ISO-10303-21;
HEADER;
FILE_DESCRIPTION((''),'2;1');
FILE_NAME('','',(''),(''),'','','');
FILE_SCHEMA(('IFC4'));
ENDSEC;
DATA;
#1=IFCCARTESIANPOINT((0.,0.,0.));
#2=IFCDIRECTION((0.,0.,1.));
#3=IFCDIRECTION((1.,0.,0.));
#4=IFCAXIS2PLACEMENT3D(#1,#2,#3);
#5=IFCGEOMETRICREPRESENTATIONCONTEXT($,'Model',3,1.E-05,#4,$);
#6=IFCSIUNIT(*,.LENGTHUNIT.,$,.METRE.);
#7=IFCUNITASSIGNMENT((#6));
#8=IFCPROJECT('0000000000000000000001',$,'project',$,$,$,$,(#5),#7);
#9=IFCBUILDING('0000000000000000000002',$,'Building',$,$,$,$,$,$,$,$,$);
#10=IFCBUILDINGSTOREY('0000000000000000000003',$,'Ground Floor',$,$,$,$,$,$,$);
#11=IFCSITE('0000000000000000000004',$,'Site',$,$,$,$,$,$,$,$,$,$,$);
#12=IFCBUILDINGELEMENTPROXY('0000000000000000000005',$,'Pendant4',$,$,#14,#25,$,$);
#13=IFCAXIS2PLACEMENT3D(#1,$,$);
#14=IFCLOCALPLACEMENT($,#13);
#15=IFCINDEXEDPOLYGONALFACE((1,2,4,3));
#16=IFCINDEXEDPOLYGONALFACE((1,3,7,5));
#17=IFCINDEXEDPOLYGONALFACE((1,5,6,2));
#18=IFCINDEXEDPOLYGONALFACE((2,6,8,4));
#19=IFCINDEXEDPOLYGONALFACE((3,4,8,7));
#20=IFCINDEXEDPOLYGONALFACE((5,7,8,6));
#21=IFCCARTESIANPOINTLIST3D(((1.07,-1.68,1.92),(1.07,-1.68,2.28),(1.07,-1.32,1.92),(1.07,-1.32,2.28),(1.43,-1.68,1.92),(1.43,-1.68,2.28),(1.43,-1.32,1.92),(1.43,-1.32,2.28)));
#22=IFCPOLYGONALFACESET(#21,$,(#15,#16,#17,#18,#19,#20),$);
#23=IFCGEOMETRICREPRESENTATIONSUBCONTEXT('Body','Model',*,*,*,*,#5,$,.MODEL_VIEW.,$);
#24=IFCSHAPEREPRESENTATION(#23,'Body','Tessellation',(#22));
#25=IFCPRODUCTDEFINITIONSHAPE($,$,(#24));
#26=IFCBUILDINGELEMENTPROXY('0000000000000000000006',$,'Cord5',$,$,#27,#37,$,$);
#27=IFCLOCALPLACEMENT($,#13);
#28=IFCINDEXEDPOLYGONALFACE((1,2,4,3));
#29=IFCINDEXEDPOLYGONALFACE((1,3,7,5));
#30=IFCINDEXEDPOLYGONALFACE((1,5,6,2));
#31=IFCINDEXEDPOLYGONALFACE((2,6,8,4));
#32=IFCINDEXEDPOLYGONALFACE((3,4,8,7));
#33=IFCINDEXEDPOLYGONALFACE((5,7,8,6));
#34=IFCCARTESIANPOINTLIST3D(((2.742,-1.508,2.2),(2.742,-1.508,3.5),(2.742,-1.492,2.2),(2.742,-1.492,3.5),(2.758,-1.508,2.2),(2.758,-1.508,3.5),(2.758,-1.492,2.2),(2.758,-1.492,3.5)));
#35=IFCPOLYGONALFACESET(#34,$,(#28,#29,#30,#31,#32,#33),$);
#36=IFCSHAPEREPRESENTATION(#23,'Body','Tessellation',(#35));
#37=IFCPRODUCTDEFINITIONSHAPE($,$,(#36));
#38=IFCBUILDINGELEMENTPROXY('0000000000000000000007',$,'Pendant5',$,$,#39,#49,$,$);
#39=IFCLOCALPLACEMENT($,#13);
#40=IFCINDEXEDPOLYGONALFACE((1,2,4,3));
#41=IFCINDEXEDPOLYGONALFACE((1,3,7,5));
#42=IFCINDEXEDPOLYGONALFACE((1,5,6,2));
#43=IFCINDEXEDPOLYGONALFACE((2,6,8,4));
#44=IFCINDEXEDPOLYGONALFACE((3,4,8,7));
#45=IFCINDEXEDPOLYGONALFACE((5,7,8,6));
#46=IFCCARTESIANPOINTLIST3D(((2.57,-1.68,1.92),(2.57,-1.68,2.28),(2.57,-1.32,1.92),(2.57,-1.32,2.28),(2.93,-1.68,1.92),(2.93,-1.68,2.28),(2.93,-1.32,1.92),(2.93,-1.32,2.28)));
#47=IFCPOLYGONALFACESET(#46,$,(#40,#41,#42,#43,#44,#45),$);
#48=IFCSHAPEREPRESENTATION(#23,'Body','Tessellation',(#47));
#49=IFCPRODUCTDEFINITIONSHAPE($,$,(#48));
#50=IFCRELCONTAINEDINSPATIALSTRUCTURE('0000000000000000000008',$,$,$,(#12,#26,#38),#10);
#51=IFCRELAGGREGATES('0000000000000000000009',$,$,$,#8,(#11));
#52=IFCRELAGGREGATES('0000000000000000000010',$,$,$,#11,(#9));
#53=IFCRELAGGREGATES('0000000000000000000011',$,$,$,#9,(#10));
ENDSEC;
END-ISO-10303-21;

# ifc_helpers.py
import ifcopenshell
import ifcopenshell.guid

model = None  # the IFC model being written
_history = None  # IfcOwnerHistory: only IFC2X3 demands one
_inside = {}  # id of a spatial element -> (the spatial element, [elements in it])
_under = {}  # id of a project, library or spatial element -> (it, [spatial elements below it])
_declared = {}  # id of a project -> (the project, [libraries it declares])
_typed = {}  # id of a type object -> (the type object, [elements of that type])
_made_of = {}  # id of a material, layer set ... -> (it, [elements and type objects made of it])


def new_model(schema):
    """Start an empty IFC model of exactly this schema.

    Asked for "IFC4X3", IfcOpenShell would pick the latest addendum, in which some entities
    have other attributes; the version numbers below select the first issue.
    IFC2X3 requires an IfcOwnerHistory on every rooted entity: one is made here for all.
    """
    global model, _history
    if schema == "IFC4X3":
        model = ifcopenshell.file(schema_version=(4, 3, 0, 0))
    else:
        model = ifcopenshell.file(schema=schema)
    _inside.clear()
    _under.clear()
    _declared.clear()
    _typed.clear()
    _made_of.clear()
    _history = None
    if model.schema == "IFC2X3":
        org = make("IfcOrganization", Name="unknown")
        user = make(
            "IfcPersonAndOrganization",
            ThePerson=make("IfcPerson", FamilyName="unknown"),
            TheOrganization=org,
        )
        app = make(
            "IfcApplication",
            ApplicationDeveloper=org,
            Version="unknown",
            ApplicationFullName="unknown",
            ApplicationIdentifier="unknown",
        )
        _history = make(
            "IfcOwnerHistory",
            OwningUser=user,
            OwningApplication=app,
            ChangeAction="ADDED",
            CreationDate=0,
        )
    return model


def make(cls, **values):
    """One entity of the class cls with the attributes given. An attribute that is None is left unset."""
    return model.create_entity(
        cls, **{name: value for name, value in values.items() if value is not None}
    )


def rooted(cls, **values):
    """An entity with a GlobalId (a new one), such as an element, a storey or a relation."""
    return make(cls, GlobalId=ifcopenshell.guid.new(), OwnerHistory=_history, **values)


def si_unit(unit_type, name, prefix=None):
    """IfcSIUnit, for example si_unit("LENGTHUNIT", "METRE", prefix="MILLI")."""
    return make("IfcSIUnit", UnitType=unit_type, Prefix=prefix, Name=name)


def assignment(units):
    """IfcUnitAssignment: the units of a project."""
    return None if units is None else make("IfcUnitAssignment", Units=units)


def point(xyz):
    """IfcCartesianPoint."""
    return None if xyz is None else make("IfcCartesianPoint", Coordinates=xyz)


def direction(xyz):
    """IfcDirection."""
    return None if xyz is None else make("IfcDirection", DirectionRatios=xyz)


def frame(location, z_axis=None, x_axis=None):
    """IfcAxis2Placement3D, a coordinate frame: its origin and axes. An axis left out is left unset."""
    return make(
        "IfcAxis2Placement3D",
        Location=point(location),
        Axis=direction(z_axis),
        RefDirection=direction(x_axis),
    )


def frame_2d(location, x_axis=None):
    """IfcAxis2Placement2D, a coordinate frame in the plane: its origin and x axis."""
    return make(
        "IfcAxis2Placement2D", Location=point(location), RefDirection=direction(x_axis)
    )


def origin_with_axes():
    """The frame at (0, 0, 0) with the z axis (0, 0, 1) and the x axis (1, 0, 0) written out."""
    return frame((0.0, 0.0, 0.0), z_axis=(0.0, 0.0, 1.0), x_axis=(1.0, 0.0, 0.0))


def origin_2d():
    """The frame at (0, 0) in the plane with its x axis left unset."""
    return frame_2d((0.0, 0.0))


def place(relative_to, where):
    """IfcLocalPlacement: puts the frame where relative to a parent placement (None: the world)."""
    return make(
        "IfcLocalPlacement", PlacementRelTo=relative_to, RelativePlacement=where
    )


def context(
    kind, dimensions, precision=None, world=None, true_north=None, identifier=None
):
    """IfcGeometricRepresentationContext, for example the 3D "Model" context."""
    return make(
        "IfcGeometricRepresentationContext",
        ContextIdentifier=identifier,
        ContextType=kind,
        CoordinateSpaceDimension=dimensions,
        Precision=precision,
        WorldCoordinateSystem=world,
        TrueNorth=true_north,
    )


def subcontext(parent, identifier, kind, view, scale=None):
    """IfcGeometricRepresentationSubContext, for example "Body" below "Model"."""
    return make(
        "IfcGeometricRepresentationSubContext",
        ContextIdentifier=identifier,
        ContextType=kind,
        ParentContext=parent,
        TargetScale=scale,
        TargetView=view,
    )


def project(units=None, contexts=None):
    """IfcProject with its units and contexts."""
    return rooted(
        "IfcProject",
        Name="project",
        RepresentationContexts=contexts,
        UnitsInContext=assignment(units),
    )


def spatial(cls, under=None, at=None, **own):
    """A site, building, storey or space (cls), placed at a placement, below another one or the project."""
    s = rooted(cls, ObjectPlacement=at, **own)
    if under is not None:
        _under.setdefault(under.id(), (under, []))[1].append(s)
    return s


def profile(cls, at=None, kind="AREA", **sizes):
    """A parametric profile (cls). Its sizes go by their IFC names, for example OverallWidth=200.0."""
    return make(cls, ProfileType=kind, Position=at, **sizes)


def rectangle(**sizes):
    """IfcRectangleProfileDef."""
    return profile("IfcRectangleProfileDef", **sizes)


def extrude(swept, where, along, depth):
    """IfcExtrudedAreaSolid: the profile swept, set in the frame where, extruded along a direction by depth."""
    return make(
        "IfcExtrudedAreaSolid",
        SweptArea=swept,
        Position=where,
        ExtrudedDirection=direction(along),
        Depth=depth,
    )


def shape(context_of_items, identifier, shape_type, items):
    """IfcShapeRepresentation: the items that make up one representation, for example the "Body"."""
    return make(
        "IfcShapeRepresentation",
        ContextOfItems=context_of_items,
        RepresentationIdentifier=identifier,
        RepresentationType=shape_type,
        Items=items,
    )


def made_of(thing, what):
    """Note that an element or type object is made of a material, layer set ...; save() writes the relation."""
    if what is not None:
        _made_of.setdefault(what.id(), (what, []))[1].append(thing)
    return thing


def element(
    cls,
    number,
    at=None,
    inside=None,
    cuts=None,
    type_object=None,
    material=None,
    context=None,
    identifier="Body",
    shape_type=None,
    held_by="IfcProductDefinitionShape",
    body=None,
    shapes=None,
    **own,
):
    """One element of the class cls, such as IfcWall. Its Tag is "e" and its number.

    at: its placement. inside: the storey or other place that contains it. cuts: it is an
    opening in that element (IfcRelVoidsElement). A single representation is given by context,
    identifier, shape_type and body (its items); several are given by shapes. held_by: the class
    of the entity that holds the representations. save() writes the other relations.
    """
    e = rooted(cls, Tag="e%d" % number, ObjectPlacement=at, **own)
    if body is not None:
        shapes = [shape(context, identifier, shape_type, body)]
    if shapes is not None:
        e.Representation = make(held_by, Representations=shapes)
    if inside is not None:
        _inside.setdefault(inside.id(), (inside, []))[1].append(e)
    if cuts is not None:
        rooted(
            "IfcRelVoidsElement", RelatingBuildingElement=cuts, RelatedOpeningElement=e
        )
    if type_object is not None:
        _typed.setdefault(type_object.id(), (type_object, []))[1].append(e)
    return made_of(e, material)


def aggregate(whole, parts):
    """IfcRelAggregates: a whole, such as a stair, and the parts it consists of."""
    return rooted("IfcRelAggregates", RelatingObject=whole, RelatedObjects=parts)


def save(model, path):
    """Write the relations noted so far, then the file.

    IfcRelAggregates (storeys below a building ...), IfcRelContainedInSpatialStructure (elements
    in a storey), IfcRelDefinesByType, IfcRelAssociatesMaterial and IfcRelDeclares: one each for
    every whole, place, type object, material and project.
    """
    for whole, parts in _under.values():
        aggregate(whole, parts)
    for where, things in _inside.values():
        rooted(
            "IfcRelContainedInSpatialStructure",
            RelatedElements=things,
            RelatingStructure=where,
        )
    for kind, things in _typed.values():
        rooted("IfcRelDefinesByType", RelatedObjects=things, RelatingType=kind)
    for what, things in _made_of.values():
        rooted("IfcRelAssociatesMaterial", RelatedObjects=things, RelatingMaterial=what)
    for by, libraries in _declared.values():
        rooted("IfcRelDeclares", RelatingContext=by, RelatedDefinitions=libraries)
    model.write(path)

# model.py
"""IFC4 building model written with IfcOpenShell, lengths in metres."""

from ifc_helpers import new_model, si_unit, frame, origin_with_axes, origin_2d, place, context, subcontext, project, spatial, rectangle, extrude, element, save


model = new_model("IFC4")

# Units and contexts
model_context = context("Model", 3, precision=1e-05, world=origin_with_axes())
body_context = subcontext(model_context, "Body", "Model", "MODEL_VIEW")
ifc_project = project(units=[si_unit("LENGTHUNIT", "METRE")], contexts=[model_context])

# Site, building, storey
site = spatial("IfcSite", under=ifc_project, Name="Site")
building = spatial("IfcBuilding", under=site, Name="Building")
storey = spatial("IfcBuildingStorey", under=building, Name="Ground Floor")

# Building element proxies
proxy_1_placement = place(None, frame((1.25, -1.5, 2.1), z_axis=(0.0, 0.0, 1.0), x_axis=(1.0, 0.0, 0.0)))
element("IfcBuildingElementProxy", 1, at=proxy_1_placement, inside=storey, Name="Pendant4", context=body_context, shape_type="SweptSolid", body=[
    extrude(rectangle(XDim=0.36, YDim=0.36, at=origin_2d()), frame((0.0, 0.0, -0.18)), (0.0, 0.0, 1.0), 0.36),
])
proxy_2_placement = place(None, frame((2.75, -1.5, 2.85), z_axis=(0.0, 0.0, 1.0), x_axis=(1.0, 0.0, 0.0)))
element("IfcBuildingElementProxy", 2, at=proxy_2_placement, inside=storey, Name="Cord5", context=body_context, shape_type="SweptSolid", body=[
    extrude(rectangle(XDim=0.016, YDim=0.016, at=origin_2d()), frame((0.0, 0.0, -0.65)), (0.0, 0.0, 1.0), 1.3),
])
proxy_3_placement = place(None, frame((2.75, -1.5, 2.1), z_axis=(0.0, 0.0, 1.0), x_axis=(1.0, 0.0, 0.0)))
element("IfcBuildingElementProxy", 3, at=proxy_3_placement, inside=storey, Name="Pendant5", context=body_context, shape_type="SweptSolid", body=[
    extrude(rectangle(XDim=0.36, YDim=0.36, at=origin_2d()), frame((0.0, 0.0, -0.18)), (0.0, 0.0, 1.0), 0.36),
])

save(model, "model.ifc")
